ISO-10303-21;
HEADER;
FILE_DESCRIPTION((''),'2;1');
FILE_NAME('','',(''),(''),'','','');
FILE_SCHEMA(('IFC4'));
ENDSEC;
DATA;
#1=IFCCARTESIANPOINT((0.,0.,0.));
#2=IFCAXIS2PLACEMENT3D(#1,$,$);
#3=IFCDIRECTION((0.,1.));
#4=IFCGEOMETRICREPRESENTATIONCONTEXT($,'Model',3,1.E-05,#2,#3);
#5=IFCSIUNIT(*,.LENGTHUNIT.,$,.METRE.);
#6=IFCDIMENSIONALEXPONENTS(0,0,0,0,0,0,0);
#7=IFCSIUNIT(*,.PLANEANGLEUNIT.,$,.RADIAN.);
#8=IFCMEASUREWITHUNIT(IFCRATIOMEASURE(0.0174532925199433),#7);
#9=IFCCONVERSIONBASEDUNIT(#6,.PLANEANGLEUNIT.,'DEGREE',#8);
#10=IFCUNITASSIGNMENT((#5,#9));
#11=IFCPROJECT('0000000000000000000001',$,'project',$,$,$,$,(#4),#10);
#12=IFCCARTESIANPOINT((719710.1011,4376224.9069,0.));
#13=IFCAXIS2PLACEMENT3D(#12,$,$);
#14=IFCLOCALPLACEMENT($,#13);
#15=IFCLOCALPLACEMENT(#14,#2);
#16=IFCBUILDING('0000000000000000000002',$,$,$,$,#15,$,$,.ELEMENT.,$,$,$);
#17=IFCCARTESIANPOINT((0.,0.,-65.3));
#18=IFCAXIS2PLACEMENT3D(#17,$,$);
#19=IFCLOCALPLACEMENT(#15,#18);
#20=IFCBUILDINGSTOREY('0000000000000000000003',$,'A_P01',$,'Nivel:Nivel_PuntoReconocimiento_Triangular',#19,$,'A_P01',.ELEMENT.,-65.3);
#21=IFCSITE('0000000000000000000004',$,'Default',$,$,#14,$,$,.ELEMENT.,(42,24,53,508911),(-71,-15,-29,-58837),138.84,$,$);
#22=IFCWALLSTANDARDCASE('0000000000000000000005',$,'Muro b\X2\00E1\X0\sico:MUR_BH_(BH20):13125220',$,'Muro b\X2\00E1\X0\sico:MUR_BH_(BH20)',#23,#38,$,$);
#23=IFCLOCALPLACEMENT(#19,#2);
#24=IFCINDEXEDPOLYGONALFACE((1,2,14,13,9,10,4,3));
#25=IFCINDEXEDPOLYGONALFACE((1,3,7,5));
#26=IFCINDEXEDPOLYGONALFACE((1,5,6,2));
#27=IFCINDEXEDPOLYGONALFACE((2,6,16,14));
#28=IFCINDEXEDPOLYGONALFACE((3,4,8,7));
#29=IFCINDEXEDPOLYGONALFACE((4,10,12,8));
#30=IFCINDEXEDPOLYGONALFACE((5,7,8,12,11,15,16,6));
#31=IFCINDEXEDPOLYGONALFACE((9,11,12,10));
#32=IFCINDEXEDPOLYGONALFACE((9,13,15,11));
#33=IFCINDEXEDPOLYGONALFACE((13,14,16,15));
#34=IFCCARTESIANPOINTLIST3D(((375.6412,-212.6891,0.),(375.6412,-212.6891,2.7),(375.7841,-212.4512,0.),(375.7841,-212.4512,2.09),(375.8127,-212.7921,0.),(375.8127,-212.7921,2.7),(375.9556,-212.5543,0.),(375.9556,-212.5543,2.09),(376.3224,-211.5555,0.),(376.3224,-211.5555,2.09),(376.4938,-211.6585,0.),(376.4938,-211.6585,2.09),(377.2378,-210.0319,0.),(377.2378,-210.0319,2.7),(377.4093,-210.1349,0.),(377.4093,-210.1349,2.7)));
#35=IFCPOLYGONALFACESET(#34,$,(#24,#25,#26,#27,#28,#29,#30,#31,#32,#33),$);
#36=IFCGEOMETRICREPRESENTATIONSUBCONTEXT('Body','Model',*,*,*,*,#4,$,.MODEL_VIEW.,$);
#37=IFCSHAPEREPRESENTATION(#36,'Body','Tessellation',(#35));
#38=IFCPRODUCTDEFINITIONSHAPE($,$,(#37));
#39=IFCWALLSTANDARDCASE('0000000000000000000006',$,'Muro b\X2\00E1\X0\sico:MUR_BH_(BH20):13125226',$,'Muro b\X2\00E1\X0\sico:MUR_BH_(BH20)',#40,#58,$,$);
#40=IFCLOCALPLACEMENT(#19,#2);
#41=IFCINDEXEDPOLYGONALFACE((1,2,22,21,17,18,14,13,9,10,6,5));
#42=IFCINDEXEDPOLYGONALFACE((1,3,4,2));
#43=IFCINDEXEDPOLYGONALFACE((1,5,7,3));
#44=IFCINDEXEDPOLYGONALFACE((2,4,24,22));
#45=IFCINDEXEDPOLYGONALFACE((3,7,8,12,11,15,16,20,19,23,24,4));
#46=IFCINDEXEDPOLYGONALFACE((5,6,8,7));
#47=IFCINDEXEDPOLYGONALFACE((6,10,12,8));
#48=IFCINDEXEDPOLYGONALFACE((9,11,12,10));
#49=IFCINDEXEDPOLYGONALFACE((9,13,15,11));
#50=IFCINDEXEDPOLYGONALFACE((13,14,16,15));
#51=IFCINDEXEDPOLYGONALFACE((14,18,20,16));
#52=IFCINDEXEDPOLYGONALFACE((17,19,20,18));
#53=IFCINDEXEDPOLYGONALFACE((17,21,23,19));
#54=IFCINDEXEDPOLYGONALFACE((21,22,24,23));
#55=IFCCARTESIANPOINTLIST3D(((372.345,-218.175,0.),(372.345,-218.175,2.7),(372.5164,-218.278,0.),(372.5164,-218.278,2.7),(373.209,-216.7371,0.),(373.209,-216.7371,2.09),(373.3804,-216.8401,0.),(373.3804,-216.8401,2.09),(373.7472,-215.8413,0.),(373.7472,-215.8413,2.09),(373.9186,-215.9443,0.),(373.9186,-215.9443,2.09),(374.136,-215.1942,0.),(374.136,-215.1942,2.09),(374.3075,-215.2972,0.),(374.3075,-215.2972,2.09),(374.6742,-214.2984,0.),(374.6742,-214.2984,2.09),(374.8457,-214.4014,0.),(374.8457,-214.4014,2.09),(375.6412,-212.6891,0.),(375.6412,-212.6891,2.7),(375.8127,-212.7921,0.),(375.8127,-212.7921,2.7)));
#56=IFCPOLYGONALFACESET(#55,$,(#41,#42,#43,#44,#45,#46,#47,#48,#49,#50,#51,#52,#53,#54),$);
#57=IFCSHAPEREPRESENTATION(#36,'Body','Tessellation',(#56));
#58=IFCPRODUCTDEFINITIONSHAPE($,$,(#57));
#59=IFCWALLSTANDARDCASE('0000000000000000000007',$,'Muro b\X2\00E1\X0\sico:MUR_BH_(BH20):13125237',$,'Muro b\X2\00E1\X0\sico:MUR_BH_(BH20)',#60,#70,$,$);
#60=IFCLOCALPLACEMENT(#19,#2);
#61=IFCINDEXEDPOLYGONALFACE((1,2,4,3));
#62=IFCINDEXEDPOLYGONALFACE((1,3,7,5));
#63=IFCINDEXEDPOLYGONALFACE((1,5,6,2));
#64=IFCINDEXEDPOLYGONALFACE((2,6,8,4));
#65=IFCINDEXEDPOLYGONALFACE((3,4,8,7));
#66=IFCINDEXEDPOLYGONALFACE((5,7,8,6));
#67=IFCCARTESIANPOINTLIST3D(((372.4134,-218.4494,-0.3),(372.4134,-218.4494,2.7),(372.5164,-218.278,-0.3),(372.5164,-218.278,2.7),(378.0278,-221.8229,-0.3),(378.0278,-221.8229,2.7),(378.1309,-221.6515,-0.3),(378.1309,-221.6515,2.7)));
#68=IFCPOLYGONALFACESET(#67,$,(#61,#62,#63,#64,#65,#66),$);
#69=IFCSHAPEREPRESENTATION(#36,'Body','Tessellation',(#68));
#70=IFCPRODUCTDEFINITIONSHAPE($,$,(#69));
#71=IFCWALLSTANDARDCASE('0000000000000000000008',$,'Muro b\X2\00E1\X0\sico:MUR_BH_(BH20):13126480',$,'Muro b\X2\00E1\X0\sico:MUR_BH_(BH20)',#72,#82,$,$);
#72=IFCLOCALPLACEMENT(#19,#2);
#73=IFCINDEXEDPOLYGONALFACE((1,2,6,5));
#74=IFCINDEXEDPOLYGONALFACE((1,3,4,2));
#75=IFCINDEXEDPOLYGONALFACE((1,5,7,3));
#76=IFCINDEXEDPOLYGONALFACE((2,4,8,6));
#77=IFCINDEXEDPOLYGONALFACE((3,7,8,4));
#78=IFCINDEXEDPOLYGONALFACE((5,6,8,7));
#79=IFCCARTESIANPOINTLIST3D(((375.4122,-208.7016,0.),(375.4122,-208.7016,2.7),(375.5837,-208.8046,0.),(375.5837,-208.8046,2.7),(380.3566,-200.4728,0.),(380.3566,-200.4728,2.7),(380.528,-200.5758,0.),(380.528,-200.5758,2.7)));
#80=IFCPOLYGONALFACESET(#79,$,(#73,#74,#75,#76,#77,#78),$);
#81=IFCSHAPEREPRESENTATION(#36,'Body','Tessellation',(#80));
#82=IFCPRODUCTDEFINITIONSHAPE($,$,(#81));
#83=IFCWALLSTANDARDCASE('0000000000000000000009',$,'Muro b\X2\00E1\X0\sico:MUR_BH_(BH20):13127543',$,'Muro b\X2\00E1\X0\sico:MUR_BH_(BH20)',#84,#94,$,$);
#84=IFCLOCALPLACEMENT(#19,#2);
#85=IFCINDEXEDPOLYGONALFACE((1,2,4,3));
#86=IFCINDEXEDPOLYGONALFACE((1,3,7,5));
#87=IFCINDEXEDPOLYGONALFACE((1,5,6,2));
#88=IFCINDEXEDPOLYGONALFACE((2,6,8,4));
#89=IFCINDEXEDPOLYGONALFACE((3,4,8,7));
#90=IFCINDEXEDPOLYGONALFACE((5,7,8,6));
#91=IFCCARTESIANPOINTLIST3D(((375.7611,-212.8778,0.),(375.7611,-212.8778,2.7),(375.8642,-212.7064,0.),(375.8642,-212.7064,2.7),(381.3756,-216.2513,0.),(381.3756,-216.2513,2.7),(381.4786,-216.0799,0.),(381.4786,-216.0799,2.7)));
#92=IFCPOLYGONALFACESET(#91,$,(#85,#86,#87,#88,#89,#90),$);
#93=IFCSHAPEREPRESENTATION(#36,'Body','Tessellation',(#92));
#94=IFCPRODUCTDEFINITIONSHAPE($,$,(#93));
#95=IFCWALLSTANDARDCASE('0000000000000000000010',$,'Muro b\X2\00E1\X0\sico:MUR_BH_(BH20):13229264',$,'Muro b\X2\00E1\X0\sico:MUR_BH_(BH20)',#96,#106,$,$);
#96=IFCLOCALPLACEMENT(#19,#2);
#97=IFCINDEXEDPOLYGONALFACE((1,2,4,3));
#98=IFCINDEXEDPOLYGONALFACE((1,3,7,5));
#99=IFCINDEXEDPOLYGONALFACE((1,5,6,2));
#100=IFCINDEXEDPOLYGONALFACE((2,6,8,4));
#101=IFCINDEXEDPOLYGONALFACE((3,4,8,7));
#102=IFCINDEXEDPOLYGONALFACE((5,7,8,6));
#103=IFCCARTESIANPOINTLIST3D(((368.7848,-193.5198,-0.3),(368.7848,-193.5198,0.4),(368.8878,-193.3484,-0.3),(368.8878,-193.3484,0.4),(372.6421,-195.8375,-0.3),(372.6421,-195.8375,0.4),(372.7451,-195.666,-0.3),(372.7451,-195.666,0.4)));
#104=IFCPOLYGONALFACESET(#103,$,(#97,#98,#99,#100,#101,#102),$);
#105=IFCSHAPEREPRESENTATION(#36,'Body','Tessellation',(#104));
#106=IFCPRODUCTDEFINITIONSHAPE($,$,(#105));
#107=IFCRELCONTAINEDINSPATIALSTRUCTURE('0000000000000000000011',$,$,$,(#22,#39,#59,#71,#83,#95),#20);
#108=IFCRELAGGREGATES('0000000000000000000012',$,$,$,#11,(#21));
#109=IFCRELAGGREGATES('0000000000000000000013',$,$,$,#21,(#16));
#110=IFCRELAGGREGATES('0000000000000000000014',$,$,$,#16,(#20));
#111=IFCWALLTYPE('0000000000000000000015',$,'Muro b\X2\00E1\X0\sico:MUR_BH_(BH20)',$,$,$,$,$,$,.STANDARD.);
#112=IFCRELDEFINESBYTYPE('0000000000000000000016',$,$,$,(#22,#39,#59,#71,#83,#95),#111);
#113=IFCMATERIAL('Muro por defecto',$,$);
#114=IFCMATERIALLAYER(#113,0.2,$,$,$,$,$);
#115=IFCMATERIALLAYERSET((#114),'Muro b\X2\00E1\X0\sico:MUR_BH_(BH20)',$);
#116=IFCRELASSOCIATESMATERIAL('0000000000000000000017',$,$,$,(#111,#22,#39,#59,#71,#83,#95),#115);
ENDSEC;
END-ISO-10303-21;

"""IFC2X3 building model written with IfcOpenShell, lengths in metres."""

from ifc_helpers import new_model, entity, si_unit, converted_unit, direction, frame, frame_2d, origin, place, context, subcontext, project, spatial, rectangle, extrude, material, layer, layer_set, layer_usage, type_object, element, save


model = new_model("IFC2X3")

# Units and contexts
model_context = context("Model", 3, precision=1e-05, world=origin(), true_north=direction((0.0, 1.0)))
body_context = subcontext(model_context, "Body", "Model", "MODEL_VIEW")
ifc_project = project(units=[si_unit("LENGTHUNIT", "METRE"), converted_unit("PLANEANGLEUNIT", "DEGREE", entity("IfcRatioMeasure", 0.0174532925199433), si_unit("PLANEANGLEUNIT", "RADIAN"), dimensions=[0, 0, 0, 0, 0, 0, 0])], contexts=[model_context])

# Site, building, storey
site_placement = place(None, frame((719710.1011, 4376224.9069, 0.0)))
site = spatial("IfcSite", under=ifc_project, at=site_placement, Name="Default", CompositionType="ELEMENT", RefLatitude=(42, 24, 53, 508911), RefLongitude=(-71, -15, -29, -58837), RefElevation=138.84)
building_placement = place(site_placement, origin())
building = spatial("IfcBuilding", under=site, at=building_placement, CompositionType="ELEMENT")
storey_placement = place(building_placement, frame((0.0, 0.0, -65.3)))
storey = spatial("IfcBuildingStorey", under=building, at=storey_placement, Name="A_P01", ObjectType="Nivel:Nivel_PuntoReconocimiento_Triangular", LongName="A_P01", CompositionType="ELEMENT", Elevation=-65.3)

# Shared definitions
ifc_material_1 = material(Name="Muro por defecto")
ifc_layer = layer(ifc_material_1, 0.2)
ifc_layer_set = layer_set([ifc_layer], Name="Muro básico:MUR_BH_(BH20)")
wall_type = type_object("IfcWallType", Name="Muro básico:MUR_BH_(BH20)", PredefinedType="STANDARD", material=ifc_layer_set)

# Wall, opening
ifc_layer_usage_1 = layer_usage(ifc_layer_set, "AXIS2", "NEGATIVE", 0.1)
wall_1_placement = place(storey_placement, frame((377.3236, -210.0834, 0.0), z_axis=(0.0, 0.0, 1.0), x_axis=(-0.515038, -0.857167, 0.0)))
wall_1 = element("IfcWallStandardCase", 1, at=wall_1_placement, inside=storey, type_object=wall_type, material=ifc_layer_usage_1, Name="Muro básico:MUR_BH_(BH20):13125220", ObjectType="Muro básico:MUR_BH_(BH20)", context=body_context, shape_type="SweptSolid", body=[
    extrude(rectangle(XDim=3.1, YDim=0.2, at=frame_2d((1.55, 0.0), x_axis=(-1.0, 0.0))), origin(), (0.0, 0.0, 1.0), 2.7),
])
opening_1_placement = place(wall_1_placement, frame((14.2594, -431.6304, 0.0), z_axis=(0.0, 0.0, 1.0), x_axis=(-0.515038, 0.857167, 0.0)))
element("IfcOpeningElement", 2, at=opening_1_placement, cuts=wall_1, ObjectType="Opening", context=body_context, shape_type="SweptSolid", body=[
    extrude(rectangle(XDim=2.09, YDim=1.045, at=frame_2d((0.0, 0.0), x_axis=(1.0, 0.0))), frame((376.0532, -212.0034, 1.045), z_axis=(0.857167, -0.515038, 0.0), x_axis=(0.0, 0.0, -1.0)), (0.0, 0.0, 1.0), 0.2),
])

# Wall, openings
ifc_layer_usage_2 = layer_usage(ifc_layer_set, "AXIS2", "NEGATIVE", 0.1)
wall_2_placement = place(storey_placement, frame((372.4307, -218.2265, 0.0), z_axis=(0.0, 0.0, 1.0), x_axis=(0.515038, 0.857167, 0.0)))
wall_2 = element("IfcWallStandardCase", 3, at=wall_2_placement, inside=storey, type_object=wall_type, material=ifc_layer_usage_2, Name="Muro básico:MUR_BH_(BH20):13125226", ObjectType="Muro básico:MUR_BH_(BH20)", context=body_context, shape_type="SweptSolid", body=[
    extrude(rectangle(XDim=6.4, YDim=0.2, at=frame_2d((3.2, 0.0), x_axis=(-1.0, 0.0))), origin(), (0.0, 0.0, 1.0), 2.7),
])
opening_2_placement = place(wall_2_placement, frame((-4.7594, 431.6304, 0.0), z_axis=(0.0, 0.0, 1.0), x_axis=(0.515038, -0.857167, 0.0)))
element("IfcOpeningElement", 4, at=opening_2_placement, cuts=wall_2, ObjectType="Opening", context=body_context, shape_type="SweptSolid", body=[
    extrude(rectangle(XDim=2.09, YDim=1.045, at=frame_2d((0.0, 0.0), x_axis=(1.0, 0.0))), frame((373.6495, -216.3922, 1.045), z_axis=(-0.857167, 0.515038, 0.0), x_axis=(0.0, 0.0, -1.0)), (0.0, 0.0, 1.0), 0.2),
])
opening_3_placement = place(wall_2_placement, frame((-4.7594, 431.6304, 0.0), z_axis=(0.0, 0.0, 1.0), x_axis=(0.515038, -0.857167, 0.0)))
element("IfcOpeningElement", 5, at=opening_3_placement, cuts=wall_2, ObjectType="Opening", context=body_context, shape_type="SweptSolid", body=[
    extrude(rectangle(XDim=2.09, YDim=1.045, at=frame_2d((0.0, 0.0), x_axis=(0.0, 1.0))), frame((374.5766, -214.8493, 1.045), z_axis=(-0.857167, 0.515038, 0.0), x_axis=(0.515038, 0.857167, 0.0)), (0.0, 0.0, 1.0), 0.2),
])

# Walls
ifc_layer_usage_3 = layer_usage(ifc_layer_set, "AXIS2", "NEGATIVE", 0.1)
wall_3_placement = place(storey_placement, frame((372.4649, -218.3637, -0.3), z_axis=(0.0, 0.0, 1.0), x_axis=(0.857167, -0.515038, 0.0)))
element("IfcWallStandardCase", 6, at=wall_3_placement, inside=storey, type_object=wall_type, material=ifc_layer_usage_3, Name="Muro básico:MUR_BH_(BH20):13125237", ObjectType="Muro básico:MUR_BH_(BH20)", context=body_context, shape_type="SweptSolid", body=[
    extrude(rectangle(XDim=6.55, YDim=0.2, at=frame_2d((3.275, 0.0), x_axis=(-1.0, 0.0))), origin(), (0.0, 0.0, 1.0), 3.0),
])
ifc_layer_usage_4 = layer_usage(ifc_layer_set, "AXIS2", "NEGATIVE", 0.1)
wall_4_placement = place(storey_placement, frame((375.4979, -208.7531, 0.0), z_axis=(0.0, 0.0, 1.0), x_axis=(0.515038, 0.857167, 0.0)))
element("IfcWallStandardCase", 7, at=wall_4_placement, inside=storey, type_object=wall_type, material=ifc_layer_usage_4, Name="Muro básico:MUR_BH_(BH20):13126480", ObjectType="Muro básico:MUR_BH_(BH20)", context=body_context, shape_type="SweptSolid", body=[
    extrude(rectangle(XDim=9.6, YDim=0.2, at=frame_2d((4.8, 0.0), x_axis=(-1.0, 0.0))), origin(), (0.0, 0.0, 1.0), 2.7),
])
ifc_layer_usage_5 = layer_usage(ifc_layer_set, "AXIS2", "NEGATIVE", 0.1)
wall_5_placement = place(storey_placement, frame((381.4271, -216.1656, 0.0), z_axis=(0.0, 0.0, 1.0), x_axis=(-0.857167, 0.515038, 0.0)))
element("IfcWallStandardCase", 8, at=wall_5_placement, inside=storey, type_object=wall_type, material=ifc_layer_usage_5, Name="Muro básico:MUR_BH_(BH20):13127543", ObjectType="Muro básico:MUR_BH_(BH20)", context=body_context, shape_type="SweptSolid", body=[
    extrude(rectangle(XDim=6.55, YDim=0.2, at=frame_2d((3.275, 0.0), x_axis=(-1.0, 0.0))), origin(), (0.0, 0.0, 1.0), 2.7),
])
ifc_layer_usage_6 = layer_usage(ifc_layer_set, "AXIS2", "POSITIVE", -0.1)
wall_6_placement = place(storey_placement, frame((372.6936, -195.7518, -0.3), z_axis=(0.0, 0.0, 1.0), x_axis=(-0.857167, 0.515038, 0.0)))
element("IfcWallStandardCase", 9, at=wall_6_placement, inside=storey, type_object=wall_type, material=ifc_layer_usage_6, Name="Muro básico:MUR_BH_(BH20):13229264", ObjectType="Muro básico:MUR_BH_(BH20)", context=body_context, shape_type="SweptSolid", body=[
    extrude(rectangle(XDim=4.5, YDim=0.2, at=frame_2d((2.25, 0.0), x_axis=(-1.0, 0.0))), origin(), (0.0, 0.0, 1.0), 0.7),
])

save(model, "model.ifc")
